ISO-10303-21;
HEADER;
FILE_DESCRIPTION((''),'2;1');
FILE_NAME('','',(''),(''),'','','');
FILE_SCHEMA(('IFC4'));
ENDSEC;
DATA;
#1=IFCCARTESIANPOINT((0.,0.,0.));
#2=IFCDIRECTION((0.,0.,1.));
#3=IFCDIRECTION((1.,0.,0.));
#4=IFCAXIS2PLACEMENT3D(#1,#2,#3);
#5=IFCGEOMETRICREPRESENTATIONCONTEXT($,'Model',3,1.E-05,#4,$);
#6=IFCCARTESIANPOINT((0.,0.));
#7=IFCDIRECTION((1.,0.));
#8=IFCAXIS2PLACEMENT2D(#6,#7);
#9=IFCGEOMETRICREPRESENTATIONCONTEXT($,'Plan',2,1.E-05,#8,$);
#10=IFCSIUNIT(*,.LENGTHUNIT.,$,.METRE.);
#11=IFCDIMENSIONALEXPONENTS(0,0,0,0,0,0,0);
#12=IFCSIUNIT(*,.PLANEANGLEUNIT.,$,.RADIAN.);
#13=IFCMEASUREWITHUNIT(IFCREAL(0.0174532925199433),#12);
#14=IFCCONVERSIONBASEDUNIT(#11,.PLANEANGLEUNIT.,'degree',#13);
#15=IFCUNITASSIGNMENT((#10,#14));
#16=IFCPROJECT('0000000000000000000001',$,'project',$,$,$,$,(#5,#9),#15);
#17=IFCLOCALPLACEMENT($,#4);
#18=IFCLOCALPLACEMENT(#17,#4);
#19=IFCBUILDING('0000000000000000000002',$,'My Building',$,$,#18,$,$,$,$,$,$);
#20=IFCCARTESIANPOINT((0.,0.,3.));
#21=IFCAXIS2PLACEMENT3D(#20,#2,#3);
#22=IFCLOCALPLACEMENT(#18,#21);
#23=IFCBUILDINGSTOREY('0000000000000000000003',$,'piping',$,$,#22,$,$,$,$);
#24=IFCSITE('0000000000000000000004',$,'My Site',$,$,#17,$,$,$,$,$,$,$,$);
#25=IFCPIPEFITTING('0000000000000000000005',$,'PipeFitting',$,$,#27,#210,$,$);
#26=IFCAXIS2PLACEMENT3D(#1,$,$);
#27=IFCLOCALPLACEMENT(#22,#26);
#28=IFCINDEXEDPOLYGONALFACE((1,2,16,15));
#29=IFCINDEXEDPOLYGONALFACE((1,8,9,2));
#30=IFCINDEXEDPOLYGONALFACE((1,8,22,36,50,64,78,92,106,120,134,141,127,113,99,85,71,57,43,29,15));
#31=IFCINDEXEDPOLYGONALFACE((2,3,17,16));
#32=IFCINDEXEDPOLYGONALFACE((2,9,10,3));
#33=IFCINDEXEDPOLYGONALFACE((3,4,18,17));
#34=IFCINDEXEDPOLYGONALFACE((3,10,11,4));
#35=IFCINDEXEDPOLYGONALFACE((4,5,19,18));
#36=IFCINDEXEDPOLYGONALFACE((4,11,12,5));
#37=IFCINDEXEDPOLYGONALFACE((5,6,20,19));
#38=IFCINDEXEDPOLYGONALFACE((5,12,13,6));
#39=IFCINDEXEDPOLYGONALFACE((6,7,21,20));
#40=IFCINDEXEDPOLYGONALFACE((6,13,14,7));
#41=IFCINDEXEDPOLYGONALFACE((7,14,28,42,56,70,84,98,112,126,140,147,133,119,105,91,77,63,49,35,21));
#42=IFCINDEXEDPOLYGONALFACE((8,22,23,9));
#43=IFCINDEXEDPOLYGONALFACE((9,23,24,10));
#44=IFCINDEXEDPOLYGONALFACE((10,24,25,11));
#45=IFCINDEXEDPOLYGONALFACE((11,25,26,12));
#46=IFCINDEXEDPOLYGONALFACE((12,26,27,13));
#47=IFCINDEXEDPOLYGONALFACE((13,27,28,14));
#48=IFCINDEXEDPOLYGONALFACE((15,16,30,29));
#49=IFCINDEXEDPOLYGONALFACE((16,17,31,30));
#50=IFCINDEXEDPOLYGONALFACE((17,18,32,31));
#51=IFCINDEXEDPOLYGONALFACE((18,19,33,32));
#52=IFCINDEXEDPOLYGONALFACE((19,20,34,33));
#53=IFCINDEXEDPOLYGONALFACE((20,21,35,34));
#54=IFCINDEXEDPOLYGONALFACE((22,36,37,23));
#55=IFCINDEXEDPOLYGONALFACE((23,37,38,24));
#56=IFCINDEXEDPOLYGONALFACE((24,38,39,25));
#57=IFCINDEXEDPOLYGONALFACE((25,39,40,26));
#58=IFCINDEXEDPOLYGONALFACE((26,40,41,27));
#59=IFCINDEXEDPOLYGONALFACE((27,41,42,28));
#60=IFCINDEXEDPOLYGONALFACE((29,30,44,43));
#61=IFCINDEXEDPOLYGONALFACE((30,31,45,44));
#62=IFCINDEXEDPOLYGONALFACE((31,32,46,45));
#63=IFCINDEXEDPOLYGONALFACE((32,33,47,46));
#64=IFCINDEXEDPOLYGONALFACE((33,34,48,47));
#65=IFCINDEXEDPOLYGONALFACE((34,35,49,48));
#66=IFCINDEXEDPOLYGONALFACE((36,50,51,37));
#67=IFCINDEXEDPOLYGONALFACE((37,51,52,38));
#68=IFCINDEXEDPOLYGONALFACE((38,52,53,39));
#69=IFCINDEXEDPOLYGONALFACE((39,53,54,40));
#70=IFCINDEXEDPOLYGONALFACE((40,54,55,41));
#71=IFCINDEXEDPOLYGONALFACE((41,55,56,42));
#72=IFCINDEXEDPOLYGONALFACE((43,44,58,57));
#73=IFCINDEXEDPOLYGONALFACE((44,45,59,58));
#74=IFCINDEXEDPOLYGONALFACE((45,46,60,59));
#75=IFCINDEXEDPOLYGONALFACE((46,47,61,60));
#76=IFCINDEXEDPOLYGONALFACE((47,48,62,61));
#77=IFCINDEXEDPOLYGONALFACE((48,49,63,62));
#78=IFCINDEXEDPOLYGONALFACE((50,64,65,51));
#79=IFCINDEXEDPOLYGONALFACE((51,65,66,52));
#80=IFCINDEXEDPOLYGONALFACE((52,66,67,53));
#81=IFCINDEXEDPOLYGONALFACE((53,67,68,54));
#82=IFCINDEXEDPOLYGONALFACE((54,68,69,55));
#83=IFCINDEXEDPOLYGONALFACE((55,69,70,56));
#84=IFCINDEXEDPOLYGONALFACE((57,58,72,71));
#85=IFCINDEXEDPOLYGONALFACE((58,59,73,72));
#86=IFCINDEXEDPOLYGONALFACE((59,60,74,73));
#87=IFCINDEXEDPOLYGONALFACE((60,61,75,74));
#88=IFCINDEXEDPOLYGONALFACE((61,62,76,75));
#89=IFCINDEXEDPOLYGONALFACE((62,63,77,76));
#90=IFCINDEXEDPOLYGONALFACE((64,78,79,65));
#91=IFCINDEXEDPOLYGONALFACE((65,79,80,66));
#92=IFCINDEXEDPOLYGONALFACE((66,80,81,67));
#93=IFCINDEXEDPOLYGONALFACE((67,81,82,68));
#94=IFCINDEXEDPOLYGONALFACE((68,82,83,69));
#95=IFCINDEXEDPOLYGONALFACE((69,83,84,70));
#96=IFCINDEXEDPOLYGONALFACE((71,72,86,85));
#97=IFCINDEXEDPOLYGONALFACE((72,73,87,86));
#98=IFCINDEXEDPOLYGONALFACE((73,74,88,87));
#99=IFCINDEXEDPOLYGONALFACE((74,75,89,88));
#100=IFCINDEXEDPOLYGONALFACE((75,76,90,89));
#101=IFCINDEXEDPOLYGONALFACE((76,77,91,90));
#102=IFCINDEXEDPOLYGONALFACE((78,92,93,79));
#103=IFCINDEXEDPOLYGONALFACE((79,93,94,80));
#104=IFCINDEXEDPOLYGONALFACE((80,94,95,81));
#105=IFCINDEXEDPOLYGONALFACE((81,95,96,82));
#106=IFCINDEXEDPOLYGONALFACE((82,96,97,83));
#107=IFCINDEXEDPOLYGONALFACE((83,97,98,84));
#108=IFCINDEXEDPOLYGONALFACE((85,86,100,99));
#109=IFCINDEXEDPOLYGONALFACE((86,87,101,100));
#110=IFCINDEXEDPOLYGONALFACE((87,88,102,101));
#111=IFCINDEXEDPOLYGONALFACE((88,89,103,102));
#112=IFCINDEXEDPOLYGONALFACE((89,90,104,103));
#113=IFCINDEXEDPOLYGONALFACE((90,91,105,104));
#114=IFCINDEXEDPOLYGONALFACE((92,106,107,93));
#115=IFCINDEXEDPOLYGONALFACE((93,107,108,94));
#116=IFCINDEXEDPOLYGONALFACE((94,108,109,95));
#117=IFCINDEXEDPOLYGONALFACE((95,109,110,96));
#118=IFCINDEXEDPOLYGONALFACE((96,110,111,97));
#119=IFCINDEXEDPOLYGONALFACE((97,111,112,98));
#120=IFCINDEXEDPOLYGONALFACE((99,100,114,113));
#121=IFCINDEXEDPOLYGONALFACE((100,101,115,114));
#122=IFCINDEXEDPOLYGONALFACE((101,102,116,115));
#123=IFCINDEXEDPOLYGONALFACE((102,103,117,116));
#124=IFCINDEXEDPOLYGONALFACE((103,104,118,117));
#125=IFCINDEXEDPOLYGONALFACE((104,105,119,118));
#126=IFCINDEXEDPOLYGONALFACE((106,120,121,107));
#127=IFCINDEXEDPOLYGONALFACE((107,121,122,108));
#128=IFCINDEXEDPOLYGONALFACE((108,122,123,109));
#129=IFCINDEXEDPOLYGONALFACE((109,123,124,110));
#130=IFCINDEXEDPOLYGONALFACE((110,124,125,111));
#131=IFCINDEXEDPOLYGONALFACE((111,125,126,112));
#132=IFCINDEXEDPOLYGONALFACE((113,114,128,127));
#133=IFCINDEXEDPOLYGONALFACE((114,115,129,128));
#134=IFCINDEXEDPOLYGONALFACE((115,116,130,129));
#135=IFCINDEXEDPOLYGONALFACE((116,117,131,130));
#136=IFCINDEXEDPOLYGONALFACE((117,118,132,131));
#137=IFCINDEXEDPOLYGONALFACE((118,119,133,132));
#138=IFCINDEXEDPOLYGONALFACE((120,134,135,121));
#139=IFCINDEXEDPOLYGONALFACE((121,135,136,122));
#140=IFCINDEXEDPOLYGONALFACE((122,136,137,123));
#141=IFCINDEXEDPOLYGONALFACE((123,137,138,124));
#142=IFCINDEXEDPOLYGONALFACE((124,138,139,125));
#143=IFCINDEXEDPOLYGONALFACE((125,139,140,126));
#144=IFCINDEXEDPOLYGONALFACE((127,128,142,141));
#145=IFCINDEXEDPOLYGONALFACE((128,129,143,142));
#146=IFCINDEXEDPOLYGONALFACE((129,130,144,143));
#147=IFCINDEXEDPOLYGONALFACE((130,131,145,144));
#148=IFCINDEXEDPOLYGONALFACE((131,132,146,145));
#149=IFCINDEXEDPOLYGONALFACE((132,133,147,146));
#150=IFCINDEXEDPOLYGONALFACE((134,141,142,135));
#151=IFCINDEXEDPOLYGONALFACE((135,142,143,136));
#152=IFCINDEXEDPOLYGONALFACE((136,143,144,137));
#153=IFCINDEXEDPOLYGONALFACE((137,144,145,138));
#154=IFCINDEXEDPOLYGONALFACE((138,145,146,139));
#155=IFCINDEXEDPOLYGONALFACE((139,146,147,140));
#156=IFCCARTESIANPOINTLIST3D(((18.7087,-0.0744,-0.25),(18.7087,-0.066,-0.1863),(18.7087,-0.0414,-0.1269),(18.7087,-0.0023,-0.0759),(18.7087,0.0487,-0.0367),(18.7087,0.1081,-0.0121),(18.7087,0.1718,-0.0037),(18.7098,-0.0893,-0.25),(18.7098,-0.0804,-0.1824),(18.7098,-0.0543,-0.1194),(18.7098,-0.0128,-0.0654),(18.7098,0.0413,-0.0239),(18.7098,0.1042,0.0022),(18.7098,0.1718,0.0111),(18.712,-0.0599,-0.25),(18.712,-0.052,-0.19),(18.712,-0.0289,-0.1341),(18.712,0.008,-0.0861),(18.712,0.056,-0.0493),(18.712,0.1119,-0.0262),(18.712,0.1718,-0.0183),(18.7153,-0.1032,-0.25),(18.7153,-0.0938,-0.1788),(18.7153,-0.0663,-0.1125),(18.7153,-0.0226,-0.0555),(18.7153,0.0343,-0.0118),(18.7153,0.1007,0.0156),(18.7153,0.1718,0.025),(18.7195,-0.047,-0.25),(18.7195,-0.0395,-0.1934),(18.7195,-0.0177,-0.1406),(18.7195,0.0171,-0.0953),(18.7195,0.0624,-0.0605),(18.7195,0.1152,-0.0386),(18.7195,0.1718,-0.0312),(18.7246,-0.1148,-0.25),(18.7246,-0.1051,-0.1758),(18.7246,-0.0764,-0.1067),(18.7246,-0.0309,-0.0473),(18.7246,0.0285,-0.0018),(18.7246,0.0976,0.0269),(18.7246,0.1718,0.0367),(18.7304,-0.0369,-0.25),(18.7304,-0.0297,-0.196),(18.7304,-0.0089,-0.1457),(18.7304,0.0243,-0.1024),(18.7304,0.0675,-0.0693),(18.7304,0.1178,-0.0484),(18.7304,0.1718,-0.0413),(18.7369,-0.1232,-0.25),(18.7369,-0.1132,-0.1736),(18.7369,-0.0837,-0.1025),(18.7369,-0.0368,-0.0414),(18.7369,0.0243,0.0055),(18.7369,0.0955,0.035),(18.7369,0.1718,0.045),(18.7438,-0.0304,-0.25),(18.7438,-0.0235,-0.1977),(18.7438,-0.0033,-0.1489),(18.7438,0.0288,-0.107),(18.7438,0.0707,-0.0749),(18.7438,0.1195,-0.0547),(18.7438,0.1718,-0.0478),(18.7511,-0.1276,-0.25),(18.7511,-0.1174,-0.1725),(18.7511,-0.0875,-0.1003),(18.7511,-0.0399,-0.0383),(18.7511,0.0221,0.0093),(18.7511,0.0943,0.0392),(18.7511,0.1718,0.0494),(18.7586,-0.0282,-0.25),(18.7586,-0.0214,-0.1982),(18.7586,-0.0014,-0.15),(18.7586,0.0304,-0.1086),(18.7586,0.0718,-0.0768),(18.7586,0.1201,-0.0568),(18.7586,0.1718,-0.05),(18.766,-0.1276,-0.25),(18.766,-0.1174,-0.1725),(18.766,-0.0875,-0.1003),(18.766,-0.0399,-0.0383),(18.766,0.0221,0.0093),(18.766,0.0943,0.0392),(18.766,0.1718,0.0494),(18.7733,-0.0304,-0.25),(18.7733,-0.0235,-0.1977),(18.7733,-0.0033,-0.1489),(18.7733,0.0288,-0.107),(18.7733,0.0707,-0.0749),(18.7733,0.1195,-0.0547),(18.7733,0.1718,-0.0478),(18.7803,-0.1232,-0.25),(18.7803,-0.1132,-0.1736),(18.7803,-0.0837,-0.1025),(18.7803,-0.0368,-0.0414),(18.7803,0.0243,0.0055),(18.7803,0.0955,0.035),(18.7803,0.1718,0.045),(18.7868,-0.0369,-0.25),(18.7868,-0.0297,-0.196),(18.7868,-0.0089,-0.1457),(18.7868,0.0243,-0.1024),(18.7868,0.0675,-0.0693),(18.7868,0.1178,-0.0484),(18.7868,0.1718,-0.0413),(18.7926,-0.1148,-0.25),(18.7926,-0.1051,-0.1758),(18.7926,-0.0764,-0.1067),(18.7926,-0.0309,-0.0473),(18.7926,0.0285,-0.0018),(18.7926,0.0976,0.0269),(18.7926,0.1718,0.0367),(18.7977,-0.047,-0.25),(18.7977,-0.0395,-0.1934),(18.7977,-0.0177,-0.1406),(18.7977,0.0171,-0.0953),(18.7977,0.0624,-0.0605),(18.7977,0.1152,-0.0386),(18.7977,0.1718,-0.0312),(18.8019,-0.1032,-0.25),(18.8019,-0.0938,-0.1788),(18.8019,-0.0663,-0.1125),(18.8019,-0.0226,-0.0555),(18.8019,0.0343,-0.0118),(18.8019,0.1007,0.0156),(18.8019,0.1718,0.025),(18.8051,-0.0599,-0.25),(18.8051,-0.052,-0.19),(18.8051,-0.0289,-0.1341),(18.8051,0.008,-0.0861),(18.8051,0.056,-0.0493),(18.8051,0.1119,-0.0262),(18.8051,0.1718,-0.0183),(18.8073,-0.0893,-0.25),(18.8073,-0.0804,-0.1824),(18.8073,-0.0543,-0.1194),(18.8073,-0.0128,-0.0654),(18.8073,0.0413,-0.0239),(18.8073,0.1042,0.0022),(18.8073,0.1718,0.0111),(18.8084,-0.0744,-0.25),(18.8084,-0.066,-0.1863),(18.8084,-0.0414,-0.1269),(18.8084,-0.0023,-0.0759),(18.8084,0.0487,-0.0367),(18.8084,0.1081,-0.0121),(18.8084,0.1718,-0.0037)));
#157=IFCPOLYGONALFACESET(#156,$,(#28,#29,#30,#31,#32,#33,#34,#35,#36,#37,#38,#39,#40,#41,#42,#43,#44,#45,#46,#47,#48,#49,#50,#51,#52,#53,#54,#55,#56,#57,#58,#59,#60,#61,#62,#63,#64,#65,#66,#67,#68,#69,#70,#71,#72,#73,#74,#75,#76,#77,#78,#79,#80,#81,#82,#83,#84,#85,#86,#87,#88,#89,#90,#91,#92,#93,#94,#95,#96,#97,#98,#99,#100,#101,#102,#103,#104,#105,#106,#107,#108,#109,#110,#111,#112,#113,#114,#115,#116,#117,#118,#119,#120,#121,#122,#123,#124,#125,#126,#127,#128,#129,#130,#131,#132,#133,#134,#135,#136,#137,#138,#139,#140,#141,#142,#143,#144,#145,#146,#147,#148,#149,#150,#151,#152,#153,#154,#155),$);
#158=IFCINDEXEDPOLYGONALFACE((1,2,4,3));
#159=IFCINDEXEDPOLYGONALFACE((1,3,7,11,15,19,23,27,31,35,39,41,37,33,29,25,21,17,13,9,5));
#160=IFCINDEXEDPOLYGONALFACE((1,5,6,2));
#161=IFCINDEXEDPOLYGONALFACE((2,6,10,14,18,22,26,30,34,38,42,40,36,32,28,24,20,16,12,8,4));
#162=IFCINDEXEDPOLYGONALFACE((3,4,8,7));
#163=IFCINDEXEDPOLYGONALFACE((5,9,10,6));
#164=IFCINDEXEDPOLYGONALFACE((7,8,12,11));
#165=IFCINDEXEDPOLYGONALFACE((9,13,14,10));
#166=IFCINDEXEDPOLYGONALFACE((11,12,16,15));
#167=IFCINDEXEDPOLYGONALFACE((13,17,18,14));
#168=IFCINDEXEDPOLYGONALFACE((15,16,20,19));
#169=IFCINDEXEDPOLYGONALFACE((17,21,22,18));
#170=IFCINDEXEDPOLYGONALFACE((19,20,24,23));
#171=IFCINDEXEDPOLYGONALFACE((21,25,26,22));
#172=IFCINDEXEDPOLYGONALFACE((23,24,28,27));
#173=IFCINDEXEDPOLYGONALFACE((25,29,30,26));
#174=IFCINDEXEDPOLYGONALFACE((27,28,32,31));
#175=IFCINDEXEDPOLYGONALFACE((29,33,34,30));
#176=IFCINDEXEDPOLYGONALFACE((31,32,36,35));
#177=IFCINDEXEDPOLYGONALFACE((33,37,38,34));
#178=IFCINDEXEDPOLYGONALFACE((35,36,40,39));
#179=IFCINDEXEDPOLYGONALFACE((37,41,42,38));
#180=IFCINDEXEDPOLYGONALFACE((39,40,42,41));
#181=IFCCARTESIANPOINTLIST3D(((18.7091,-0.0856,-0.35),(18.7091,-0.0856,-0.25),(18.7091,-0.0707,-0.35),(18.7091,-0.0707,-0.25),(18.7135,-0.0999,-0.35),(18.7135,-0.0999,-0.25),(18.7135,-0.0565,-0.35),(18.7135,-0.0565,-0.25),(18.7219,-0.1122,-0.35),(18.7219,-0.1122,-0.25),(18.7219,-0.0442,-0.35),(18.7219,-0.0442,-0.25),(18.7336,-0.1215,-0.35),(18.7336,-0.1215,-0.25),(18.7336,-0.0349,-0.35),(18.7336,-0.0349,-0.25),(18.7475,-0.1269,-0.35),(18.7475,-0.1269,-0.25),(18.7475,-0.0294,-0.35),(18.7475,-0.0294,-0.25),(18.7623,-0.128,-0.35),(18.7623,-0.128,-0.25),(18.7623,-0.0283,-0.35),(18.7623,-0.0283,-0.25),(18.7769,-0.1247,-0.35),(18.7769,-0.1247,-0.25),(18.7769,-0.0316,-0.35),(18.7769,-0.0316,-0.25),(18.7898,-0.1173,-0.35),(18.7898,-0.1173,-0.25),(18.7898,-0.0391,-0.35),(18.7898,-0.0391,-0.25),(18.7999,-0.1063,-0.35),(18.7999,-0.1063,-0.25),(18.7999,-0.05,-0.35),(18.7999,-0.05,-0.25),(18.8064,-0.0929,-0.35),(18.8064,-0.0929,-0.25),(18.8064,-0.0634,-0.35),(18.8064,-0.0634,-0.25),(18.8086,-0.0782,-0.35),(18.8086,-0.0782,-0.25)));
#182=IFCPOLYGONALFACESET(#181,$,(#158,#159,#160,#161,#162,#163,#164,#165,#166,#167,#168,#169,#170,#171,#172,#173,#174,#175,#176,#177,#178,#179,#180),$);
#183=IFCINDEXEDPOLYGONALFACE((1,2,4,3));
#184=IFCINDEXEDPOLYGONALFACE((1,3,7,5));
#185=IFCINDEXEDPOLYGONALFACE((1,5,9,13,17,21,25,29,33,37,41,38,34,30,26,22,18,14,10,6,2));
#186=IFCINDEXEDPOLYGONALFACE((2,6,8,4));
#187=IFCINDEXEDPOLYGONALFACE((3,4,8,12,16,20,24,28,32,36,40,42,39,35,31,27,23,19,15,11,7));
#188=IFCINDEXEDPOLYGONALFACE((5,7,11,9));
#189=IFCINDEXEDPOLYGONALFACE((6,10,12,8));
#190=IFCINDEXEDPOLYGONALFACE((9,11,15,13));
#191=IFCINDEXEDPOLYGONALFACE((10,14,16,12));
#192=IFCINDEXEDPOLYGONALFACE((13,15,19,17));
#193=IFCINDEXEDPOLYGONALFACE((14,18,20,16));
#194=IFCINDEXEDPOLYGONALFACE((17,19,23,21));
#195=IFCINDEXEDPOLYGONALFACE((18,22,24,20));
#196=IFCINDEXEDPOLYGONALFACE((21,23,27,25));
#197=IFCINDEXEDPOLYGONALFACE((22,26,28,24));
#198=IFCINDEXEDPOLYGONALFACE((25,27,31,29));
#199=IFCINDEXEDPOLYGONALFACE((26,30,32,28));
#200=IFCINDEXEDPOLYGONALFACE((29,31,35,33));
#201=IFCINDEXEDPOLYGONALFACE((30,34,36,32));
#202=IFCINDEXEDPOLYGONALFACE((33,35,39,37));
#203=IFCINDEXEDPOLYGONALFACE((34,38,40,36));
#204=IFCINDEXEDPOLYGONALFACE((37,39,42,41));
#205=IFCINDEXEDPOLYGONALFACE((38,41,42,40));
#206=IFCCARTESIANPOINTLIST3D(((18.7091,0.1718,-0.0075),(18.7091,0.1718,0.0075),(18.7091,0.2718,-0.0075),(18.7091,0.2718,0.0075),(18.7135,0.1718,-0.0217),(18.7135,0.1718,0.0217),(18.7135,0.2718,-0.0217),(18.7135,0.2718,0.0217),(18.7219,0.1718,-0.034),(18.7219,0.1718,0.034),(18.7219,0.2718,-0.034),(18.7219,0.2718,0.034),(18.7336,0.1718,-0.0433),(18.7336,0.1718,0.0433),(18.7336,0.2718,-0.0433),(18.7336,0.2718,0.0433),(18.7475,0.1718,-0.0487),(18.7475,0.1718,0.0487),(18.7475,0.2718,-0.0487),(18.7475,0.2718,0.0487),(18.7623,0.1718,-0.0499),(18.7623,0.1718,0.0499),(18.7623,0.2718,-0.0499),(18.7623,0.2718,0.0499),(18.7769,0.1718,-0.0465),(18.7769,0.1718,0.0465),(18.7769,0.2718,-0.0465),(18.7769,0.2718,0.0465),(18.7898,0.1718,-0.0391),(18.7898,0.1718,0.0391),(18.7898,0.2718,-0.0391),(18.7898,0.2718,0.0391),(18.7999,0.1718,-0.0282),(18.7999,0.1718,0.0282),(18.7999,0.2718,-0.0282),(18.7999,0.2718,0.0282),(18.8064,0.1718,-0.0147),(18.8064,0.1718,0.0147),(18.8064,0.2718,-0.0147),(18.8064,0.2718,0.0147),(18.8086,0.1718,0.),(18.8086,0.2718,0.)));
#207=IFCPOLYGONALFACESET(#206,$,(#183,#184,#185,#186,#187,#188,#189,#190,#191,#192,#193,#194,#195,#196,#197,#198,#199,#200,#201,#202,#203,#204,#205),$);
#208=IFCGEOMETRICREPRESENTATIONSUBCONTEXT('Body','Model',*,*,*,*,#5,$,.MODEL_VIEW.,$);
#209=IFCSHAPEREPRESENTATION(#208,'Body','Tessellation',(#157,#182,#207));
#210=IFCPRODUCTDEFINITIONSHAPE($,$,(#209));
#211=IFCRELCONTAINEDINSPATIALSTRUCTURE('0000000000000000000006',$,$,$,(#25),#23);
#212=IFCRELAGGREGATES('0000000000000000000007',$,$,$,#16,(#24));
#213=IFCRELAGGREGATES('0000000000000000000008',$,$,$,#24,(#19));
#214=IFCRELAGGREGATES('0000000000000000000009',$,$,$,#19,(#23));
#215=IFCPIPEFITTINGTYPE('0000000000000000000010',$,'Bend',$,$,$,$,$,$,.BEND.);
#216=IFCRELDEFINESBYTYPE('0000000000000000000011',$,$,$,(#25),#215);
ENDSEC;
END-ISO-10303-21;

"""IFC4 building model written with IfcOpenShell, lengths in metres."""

from ifc_helpers import new_model, entity, si_unit, converted_unit, frame, origin_with_axes, origin_2d_with_axis, place, context, subcontext, project, spatial, circle, extrude, source, transform, mapped, type_object, type_shapes, element, save


model = new_model("IFC4")

# Units and contexts
model_context = context("Model", 3, precision=1e-05, world=origin_with_axes())
plan_context = context("Plan", 2, precision=1e-05, world=origin_2d_with_axis())
body_context = subcontext(model_context, "Body", "Model", "MODEL_VIEW")
ifc_project = project(units=[si_unit("LENGTHUNIT", "METRE"), converted_unit("PLANEANGLEUNIT", "degree", entity("IfcReal", 0.0174532925199433), si_unit("PLANEANGLEUNIT", "RADIAN"), dimensions=[0, 0, 0, 0, 0, 0, 0])], contexts=[model_context, plan_context])

# Site, building, storey
site_placement = place(None, origin_with_axes())
site = spatial("IfcSite", under=ifc_project, at=site_placement, Name="My Site")
building_placement = place(site_placement, origin_with_axes())
building = spatial("IfcBuilding", under=site, at=building_placement, Name="My Building")
storey_placement = place(building_placement, frame((0.0, 0.0, 3.0), z_axis=(0.0, 0.0, 1.0), x_axis=(1.0, 0.0, 0.0)))
storey = spatial("IfcBuildingStorey", under=building, at=storey_placement, Name="piping")

# Pipe fitting
pipe_fitting_type = type_object("IfcPipeFittingType", Name="Bend", PredefinedType="BEND")
shared_shape = source(origin_with_axes(), body_context, "Body", "SolidModel", [
    entity("IfcSweptDiskSolid", entity("IfcIndexedPolyCurve", entity("IfcCartesianPointList3D", [[0.0, 0.0, -0.1], [0.0, -0.0732, -0.2768], [0.0, -0.25, -0.35]]), [entity("IfcArcIndex", [1, 2, 3])]), 0.05),
    extrude(circle(Radius=0.05), origin_with_axes(), (0.0, 0.0, -1.0), 0.1),
    extrude(circle(Radius=0.05), frame((0.0, -0.25, -0.35), z_axis=(0.0, -1.0, 0.0), x_axis=(1.0, 0.0, 0.0)), (0.0, 0.0, 1.0), 0.1),
])
type_shapes(pipe_fitting_type, [shared_shape])
for number, where, z_axis, x_axis, name in (
    (1, (18.7586, -0.0782, -0.35), (0.0, 0.0, -1.0), (1.0, 0.0, 0.0), "PipeFitting"),
):
    element("IfcPipeFitting", number, at=place(storey_placement, frame(where, z_axis=z_axis, x_axis=x_axis)), inside=storey, type_object=pipe_fitting_type, Name=name, context=body_context, shape_type="MappedRepresentation", body=[
        mapped(shared_shape, transform((0.0, 0.0, 0.0), x_axis=(1.0, 0.0, 0.0), y_axis=(0.0, 1.0, 0.0), z_axis=(0.0, 0.0, 1.0), scale=1.0)),
    ])

save(model, "model.ifc")
